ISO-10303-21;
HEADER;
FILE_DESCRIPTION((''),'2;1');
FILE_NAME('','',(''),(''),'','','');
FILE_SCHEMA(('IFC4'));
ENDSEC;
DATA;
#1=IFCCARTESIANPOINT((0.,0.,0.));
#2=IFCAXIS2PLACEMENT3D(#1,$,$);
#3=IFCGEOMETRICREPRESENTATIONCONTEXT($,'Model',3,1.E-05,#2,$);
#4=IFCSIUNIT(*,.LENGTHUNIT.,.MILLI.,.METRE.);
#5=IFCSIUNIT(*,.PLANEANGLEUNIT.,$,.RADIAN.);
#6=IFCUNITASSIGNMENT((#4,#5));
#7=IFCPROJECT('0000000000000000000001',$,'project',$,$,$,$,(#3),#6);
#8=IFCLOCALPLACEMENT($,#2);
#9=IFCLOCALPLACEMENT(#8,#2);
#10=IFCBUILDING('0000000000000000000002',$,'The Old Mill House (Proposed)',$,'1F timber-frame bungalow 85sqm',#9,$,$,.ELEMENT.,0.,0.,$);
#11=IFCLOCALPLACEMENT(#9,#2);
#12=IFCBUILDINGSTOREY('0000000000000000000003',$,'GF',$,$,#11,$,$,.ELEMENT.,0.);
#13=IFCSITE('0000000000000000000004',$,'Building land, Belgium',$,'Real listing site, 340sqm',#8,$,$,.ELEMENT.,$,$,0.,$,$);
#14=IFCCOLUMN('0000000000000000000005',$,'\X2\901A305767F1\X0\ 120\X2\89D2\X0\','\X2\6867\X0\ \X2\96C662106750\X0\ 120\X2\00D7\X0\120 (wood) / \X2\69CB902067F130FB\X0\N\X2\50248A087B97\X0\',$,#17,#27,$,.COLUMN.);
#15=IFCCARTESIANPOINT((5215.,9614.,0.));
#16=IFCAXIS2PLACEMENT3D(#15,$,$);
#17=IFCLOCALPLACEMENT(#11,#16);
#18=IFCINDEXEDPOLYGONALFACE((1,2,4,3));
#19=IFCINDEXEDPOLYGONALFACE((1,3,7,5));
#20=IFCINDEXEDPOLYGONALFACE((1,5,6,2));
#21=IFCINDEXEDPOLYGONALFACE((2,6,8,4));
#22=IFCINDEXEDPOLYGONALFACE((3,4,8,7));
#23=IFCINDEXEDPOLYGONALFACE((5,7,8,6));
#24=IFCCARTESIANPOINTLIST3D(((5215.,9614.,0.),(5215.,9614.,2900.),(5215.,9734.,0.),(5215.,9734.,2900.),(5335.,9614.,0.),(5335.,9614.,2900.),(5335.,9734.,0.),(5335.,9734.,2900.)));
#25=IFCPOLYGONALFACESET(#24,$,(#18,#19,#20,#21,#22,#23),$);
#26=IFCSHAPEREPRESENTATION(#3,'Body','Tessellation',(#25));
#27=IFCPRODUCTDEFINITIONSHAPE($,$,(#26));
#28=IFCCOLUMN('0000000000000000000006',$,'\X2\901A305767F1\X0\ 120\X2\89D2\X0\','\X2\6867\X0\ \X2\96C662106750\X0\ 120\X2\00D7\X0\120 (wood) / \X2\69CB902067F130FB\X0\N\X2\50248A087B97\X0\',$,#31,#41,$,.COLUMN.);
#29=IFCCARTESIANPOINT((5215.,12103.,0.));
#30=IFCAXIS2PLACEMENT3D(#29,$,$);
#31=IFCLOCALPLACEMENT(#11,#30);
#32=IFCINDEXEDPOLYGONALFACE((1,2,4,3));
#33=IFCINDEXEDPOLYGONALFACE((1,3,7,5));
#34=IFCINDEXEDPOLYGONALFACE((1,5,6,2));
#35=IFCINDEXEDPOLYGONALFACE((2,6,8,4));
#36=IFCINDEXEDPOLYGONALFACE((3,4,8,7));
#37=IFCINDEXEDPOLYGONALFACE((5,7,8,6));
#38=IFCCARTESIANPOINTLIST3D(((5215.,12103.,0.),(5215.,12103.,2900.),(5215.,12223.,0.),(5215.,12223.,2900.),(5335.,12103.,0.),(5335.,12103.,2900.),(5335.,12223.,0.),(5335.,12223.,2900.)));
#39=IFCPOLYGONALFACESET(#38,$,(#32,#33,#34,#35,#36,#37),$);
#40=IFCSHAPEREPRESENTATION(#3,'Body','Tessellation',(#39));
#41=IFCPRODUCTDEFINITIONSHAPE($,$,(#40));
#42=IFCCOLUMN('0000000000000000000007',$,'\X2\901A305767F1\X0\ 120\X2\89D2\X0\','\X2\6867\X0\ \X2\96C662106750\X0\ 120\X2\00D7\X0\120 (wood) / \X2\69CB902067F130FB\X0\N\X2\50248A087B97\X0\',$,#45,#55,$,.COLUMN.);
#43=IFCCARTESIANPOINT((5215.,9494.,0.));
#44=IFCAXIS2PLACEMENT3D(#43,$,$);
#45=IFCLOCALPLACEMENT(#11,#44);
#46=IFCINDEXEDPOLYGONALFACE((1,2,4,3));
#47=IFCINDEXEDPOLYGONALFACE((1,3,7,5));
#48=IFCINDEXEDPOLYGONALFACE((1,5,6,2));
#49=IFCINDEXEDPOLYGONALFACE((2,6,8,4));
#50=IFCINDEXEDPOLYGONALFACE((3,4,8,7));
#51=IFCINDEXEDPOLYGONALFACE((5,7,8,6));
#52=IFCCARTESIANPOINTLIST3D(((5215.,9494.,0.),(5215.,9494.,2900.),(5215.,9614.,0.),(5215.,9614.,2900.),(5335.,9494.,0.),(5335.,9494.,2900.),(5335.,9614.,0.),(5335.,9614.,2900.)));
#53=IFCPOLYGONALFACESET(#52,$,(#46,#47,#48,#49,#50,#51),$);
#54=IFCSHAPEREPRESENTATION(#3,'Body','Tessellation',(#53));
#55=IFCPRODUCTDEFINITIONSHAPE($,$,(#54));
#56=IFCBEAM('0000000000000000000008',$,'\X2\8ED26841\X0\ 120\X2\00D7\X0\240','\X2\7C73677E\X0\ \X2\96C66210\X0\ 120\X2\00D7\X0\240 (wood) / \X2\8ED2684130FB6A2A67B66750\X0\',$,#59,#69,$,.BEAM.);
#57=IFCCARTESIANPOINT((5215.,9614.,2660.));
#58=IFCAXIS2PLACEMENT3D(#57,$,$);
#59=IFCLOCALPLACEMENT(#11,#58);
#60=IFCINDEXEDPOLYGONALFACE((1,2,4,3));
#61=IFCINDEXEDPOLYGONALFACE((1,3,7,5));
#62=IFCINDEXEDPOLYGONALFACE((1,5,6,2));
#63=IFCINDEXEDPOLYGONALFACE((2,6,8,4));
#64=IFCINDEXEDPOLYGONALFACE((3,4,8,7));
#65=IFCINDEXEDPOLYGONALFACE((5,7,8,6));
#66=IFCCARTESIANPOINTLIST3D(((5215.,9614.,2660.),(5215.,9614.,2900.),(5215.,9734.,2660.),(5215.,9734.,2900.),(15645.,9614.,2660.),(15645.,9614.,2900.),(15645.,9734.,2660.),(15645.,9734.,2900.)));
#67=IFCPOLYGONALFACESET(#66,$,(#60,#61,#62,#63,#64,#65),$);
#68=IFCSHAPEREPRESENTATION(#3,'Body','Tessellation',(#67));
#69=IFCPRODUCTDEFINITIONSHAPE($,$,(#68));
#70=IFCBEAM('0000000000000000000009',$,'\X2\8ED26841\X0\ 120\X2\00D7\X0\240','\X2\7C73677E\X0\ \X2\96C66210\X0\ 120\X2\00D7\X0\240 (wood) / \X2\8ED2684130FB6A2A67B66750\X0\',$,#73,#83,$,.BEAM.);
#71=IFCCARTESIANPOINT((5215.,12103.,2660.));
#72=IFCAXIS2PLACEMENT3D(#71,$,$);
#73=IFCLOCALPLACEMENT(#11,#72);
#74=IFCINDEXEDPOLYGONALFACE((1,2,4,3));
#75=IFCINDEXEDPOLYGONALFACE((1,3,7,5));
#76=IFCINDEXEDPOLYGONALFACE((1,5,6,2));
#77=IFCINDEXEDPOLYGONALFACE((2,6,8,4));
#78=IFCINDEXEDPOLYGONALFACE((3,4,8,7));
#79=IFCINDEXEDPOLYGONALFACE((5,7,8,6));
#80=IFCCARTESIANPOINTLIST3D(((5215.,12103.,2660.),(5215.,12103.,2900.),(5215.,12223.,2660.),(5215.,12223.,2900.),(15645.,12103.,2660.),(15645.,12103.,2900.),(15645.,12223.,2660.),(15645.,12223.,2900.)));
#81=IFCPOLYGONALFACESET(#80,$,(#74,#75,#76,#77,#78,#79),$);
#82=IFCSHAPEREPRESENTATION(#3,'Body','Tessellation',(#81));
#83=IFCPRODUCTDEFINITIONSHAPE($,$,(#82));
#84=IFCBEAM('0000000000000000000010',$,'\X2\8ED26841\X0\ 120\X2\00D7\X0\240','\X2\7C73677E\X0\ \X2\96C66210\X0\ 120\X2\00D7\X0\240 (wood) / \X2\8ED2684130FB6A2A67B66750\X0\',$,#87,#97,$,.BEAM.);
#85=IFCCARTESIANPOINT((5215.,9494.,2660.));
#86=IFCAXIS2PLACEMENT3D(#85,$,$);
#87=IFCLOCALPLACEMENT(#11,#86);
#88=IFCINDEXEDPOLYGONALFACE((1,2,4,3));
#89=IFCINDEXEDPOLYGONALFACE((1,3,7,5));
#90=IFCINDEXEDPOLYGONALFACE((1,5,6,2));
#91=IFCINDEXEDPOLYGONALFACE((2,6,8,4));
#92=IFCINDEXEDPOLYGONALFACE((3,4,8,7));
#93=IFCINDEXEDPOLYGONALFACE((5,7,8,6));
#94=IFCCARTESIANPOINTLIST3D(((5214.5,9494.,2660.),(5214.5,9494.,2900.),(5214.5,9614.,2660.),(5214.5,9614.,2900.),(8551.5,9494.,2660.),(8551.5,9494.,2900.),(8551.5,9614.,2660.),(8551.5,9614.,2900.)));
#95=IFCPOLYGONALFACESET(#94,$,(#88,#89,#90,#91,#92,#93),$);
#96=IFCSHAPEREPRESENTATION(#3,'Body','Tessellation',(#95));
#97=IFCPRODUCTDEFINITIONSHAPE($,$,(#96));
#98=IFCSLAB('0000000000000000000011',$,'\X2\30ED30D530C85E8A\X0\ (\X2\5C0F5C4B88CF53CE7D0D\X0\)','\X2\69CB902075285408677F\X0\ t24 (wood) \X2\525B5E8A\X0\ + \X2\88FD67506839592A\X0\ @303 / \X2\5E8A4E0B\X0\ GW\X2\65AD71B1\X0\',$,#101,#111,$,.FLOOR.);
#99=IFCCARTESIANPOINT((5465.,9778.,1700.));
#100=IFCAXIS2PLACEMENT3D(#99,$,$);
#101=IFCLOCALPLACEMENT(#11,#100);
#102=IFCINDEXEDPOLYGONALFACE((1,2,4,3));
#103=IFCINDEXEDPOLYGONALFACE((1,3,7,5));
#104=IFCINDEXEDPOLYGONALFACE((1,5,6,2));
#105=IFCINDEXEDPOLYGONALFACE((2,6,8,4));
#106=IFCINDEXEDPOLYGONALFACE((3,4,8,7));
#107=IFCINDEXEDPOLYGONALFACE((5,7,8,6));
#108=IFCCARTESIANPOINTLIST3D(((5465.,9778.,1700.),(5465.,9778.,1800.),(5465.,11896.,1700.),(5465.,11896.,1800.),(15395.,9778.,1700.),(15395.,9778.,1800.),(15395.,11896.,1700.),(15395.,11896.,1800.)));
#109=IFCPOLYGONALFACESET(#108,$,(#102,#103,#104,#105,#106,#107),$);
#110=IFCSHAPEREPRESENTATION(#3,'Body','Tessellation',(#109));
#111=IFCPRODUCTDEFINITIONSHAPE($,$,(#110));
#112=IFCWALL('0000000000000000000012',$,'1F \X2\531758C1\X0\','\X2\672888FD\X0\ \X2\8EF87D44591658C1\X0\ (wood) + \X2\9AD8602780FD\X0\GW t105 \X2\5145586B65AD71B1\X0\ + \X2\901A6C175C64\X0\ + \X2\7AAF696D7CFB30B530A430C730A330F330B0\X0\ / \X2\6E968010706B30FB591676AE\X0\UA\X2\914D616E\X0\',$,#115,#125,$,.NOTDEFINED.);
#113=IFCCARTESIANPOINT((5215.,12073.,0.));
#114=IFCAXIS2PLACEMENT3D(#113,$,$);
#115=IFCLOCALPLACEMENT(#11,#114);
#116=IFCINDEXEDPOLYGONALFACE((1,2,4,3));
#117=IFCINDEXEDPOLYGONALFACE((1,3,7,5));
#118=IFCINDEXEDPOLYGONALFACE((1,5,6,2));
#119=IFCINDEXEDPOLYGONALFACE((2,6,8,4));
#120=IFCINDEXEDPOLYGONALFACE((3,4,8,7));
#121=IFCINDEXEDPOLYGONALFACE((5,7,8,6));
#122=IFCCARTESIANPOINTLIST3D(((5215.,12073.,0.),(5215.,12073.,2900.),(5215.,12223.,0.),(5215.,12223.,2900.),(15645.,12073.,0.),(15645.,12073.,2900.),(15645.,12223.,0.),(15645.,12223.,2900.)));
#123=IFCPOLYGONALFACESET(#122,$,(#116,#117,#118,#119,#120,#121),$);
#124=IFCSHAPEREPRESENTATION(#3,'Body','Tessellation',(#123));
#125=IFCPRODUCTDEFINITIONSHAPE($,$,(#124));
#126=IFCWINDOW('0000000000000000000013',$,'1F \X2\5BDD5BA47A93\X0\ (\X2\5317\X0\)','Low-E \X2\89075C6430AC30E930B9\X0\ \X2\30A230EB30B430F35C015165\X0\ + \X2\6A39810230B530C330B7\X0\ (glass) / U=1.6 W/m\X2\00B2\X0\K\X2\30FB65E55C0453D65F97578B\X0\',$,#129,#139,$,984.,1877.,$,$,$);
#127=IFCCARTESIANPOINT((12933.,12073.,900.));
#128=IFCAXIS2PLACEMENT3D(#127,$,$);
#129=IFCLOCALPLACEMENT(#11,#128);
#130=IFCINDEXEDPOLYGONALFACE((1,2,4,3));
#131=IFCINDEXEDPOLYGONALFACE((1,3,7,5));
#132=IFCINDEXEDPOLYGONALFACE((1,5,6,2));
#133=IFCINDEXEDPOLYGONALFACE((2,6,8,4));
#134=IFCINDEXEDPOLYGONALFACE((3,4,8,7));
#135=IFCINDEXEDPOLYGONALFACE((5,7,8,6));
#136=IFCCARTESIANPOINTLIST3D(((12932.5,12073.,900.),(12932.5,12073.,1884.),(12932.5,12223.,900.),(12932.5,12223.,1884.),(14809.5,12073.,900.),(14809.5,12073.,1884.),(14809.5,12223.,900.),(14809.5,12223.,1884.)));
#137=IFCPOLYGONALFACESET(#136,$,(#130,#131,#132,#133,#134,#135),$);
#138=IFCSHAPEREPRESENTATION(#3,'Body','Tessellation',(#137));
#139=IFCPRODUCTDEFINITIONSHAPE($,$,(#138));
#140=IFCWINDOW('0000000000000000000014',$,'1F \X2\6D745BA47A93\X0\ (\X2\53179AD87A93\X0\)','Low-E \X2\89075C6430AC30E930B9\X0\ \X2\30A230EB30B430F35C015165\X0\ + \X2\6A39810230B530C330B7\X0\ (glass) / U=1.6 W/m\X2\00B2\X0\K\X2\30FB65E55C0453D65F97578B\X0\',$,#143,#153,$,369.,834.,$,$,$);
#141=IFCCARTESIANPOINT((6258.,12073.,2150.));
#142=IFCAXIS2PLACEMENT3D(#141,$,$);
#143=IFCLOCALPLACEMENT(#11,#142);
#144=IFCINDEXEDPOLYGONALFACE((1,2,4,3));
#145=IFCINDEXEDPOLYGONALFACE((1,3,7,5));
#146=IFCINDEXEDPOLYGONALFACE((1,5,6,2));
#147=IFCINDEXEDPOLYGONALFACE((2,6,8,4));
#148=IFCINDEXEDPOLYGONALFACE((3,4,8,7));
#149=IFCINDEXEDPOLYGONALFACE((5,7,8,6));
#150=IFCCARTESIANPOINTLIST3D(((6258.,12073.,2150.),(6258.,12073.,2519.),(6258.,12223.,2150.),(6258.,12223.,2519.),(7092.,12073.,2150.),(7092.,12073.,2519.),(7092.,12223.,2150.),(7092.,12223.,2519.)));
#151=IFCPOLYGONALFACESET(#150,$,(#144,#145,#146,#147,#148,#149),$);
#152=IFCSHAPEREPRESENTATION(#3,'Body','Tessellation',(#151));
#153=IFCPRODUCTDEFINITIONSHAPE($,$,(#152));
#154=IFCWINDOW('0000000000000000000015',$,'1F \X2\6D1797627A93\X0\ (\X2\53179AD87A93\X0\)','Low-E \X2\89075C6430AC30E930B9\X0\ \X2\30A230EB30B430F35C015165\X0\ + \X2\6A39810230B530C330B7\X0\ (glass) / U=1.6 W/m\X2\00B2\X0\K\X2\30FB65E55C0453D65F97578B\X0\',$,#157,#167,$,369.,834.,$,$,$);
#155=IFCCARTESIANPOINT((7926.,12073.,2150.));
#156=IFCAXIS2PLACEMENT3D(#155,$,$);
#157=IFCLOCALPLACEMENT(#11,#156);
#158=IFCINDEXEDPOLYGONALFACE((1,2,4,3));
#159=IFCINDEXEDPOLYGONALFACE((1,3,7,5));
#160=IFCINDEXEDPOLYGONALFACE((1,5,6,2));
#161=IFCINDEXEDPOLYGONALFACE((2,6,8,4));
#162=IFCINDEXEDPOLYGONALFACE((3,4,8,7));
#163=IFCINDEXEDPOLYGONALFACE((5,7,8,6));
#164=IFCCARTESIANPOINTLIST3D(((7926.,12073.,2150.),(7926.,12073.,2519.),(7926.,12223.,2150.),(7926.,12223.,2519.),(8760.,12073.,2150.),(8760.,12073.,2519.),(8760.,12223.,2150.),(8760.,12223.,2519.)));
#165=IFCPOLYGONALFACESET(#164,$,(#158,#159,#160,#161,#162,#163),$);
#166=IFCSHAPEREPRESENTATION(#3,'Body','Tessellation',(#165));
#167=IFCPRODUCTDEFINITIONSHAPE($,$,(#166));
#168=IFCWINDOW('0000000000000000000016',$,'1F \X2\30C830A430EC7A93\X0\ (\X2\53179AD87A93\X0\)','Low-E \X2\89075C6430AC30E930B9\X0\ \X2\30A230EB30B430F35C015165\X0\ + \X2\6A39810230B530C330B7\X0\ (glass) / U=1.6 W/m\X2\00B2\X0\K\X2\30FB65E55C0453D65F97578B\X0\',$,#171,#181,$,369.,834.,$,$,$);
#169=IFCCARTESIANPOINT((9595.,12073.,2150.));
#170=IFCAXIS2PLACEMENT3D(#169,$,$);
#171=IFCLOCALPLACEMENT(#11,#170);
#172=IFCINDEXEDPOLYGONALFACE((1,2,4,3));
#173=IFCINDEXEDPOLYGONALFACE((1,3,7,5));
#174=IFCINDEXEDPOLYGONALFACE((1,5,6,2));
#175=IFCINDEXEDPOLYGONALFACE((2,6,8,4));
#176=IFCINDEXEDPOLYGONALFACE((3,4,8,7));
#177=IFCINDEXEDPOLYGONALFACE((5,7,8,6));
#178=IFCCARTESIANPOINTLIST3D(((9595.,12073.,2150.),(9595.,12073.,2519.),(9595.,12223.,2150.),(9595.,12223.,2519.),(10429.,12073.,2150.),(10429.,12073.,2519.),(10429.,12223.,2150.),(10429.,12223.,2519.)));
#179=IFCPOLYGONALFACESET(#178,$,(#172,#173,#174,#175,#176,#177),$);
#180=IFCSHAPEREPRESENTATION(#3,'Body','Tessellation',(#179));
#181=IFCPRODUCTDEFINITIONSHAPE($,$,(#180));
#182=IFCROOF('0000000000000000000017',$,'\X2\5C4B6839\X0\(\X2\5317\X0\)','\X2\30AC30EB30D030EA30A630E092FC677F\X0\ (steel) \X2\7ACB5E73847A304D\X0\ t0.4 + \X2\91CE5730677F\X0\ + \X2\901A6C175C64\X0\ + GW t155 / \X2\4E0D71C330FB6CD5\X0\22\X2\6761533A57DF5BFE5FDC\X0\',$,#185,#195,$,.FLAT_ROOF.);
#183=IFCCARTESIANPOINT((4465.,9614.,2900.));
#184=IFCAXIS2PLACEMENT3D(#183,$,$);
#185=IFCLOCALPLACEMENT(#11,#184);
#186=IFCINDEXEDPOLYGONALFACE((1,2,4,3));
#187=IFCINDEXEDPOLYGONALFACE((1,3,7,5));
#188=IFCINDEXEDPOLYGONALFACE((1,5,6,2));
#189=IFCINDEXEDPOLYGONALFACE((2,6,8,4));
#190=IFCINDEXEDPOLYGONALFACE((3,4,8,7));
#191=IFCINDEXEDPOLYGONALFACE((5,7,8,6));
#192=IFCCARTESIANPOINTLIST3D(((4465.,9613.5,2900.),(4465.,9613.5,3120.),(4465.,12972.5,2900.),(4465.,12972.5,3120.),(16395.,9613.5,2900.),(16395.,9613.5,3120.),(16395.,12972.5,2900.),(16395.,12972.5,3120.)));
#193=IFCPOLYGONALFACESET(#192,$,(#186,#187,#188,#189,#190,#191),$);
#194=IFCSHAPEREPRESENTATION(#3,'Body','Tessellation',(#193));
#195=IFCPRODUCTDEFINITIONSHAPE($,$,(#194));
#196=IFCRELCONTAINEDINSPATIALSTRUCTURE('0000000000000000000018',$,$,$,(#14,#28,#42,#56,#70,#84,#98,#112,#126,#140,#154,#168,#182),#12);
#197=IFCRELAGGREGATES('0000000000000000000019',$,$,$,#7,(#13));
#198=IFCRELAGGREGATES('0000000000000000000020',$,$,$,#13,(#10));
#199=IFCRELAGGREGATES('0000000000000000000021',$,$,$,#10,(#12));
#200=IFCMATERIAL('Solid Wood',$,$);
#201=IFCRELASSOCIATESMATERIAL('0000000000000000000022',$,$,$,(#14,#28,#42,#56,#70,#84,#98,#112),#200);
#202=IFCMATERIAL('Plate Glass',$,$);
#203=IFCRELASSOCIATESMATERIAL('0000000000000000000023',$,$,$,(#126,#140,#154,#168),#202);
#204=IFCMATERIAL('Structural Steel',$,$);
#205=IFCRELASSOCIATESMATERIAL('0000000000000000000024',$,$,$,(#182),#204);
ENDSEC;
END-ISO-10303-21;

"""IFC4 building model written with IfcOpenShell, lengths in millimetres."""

from ifc_helpers import new_model, si_unit, frame, frame_2d, origin, place, context, project, spatial, rectangle, extrude, material, element, fill, save


model = new_model("IFC4")

# Units and contexts
model_context = context("Model", 3, precision=1e-05, world=origin())
ifc_project = project(units=[si_unit("LENGTHUNIT", "METRE", prefix="MILLI"), si_unit("PLANEANGLEUNIT", "RADIAN")], contexts=[model_context])

# Site, building, storey
site_placement = place(None, origin())
site = spatial("IfcSite", under=ifc_project, at=site_placement, Name="Building land, Belgium", ObjectType="Real listing site, 340sqm", CompositionType="ELEMENT", RefElevation=0.0)
building_placement = place(site_placement, origin())
building = spatial("IfcBuilding", under=site, at=building_placement, Name="The Old Mill House (Proposed)", ObjectType="1F timber-frame bungalow 85sqm", CompositionType="ELEMENT", ElevationOfRefHeight=0.0, ElevationOfTerrain=0.0)
storey_placement = place(building_placement, origin())
storey = spatial("IfcBuildingStorey", under=building, at=storey_placement, Name="GF", CompositionType="ELEMENT", Elevation=0.0)

# Columns
ifc_material_1 = material(Name="Solid Wood")
column_1_placement = place(storey_placement, frame((5215.0, 9614.0, 0.0)))
element("IfcColumn", 1, at=column_1_placement, inside=storey, material=ifc_material_1, Name="通し柱 120角", Description="桧 集成材 120×120 (wood) / 構造柱・N値計算", PredefinedType="COLUMN", context=model_context, shape_type="SweptSolid", body=[
    extrude(rectangle(XDim=120.0, YDim=120.0, at=frame_2d((60.0, 60.0))), frame((5215.0, 9614.0, 0.0)), (0.0, 0.0, 1.0), 2900.0),
])
column_2_placement = place(storey_placement, frame((5215.0, 12103.0, 0.0)))
element("IfcColumn", 2, at=column_2_placement, inside=storey, material=ifc_material_1, Name="通し柱 120角", Description="桧 集成材 120×120 (wood) / 構造柱・N値計算", PredefinedType="COLUMN", context=model_context, shape_type="SweptSolid", body=[
    extrude(rectangle(XDim=120.0, YDim=120.0, at=frame_2d((60.0, 60.0))), frame((5215.0, 12103.0, 0.0)), (0.0, 0.0, 1.0), 2900.0),
])
column_3_placement = place(storey_placement, frame((5215.0, 9494.0, 0.0)))
element("IfcColumn", 3, at=column_3_placement, inside=storey, material=ifc_material_1, Name="通し柱 120角", Description="桧 集成材 120×120 (wood) / 構造柱・N値計算", PredefinedType="COLUMN", context=model_context, shape_type="SweptSolid", body=[
    extrude(rectangle(XDim=120.0, YDim=120.0, at=frame_2d((60.0, 60.0))), frame((5215.0, 9494.0, 0.0)), (0.0, 0.0, 1.0), 2900.0),
])

# Beams
beam_1_placement = place(storey_placement, frame((5215.0, 9614.0, 2660.0)))
element("IfcBeam", 4, at=beam_1_placement, inside=storey, material=ifc_material_1, Name="軒桁 120×240", Description="米松 集成 120×240 (wood) / 軒桁・横架材", PredefinedType="BEAM", context=model_context, shape_type="SweptSolid", body=[
    extrude(rectangle(XDim=10430.0, YDim=120.0, at=frame_2d((5215.0, 60.0))), frame((5215.0, 9614.0, 2660.0)), (0.0, 0.0, 1.0), 240.0),
])
beam_2_placement = place(storey_placement, frame((5215.0, 12103.0, 2660.0)))
element("IfcBeam", 5, at=beam_2_placement, inside=storey, material=ifc_material_1, Name="軒桁 120×240", Description="米松 集成 120×240 (wood) / 軒桁・横架材", PredefinedType="BEAM", context=model_context, shape_type="SweptSolid", body=[
    extrude(rectangle(XDim=10430.0, YDim=120.0, at=frame_2d((5215.0, 60.0))), frame((5215.0, 12103.0, 2660.0)), (0.0, 0.0, 1.0), 240.0),
])
beam_3_placement = place(storey_placement, frame((5215.0, 9494.0, 2660.0)))
element("IfcBeam", 6, at=beam_3_placement, inside=storey, material=ifc_material_1, Name="軒桁 120×240", Description="米松 集成 120×240 (wood) / 軒桁・横架材", PredefinedType="BEAM", context=model_context, shape_type="SweptSolid", body=[
    extrude(rectangle(XDim=3337.0, YDim=120.0, at=frame_2d((1668.0, 60.0))), frame((5215.0, 9494.0, 2660.0)), (0.0, 0.0, 1.0), 240.0),
])

# Slab
slab_1_placement = place(storey_placement, frame((5465.0, 9778.0, 1700.0)))
element("IfcSlab", 7, at=slab_1_placement, inside=storey, material=ifc_material_1, Name="ロフト床 (小屋裏収納)", Description="構造用合板 t24 (wood) 剛床 + 製材根太 @303 / 床下 GW断熱", PredefinedType="FLOOR", context=model_context, shape_type="SweptSolid", body=[
    extrude(rectangle(XDim=9930.0, YDim=2118.0, at=frame_2d((4965.0, 1059.0))), frame((5465.0, 9778.0, 1700.0)), (0.0, 0.0, 1.0), 100.0),
])

# Wall, openings, windows
wall_1_placement = place(storey_placement, frame((5215.0, 12073.0, 0.0)))
wall_1 = element("IfcWall", 8, at=wall_1_placement, inside=storey, material=ifc_material_1, Name="1F 北壁", Description="木製 軸組外壁 (wood) + 高性能GW t105 充填断熱 + 通気層 + 窯業系サイディング / 準耐火・外皮UA配慮", PredefinedType="NOTDEFINED", context=model_context, shape_type="SweptSolid", body=[
    extrude(rectangle(XDim=10430.0, YDim=150.0, at=frame_2d((5215.0, 75.0))), frame((5215.0, 12073.0, 0.0)), (0.0, 0.0, 1.0), 2900.0),
])
opening_1_placement = place(storey_placement, frame((12933.0, 12073.0, 900.0)))
opening_1 = element("IfcOpeningElement", 9, at=opening_1_placement, cuts=wall_1, PredefinedType="NOTDEFINED", context=model_context, shape_type="SweptSolid", body=[
    extrude(rectangle(XDim=1877.0, YDim=150.0, at=frame_2d((938.0, 75.0))), frame((12933.0, 12073.0, 900.0)), (0.0, 0.0, 1.0), 984.0),
])
opening_2_placement = place(storey_placement, frame((6258.0, 12073.0, 2150.0)))
opening_2 = element("IfcOpeningElement", 10, at=opening_2_placement, cuts=wall_1, PredefinedType="NOTDEFINED", context=model_context, shape_type="SweptSolid", body=[
    extrude(rectangle(XDim=834.0, YDim=150.0, at=frame_2d((417.0, 75.0))), frame((6258.0, 12073.0, 2150.0)), (0.0, 0.0, 1.0), 369.0),
])
opening_3_placement = place(storey_placement, frame((7926.0, 12073.0, 2150.0)))
opening_3 = element("IfcOpeningElement", 11, at=opening_3_placement, cuts=wall_1, PredefinedType="NOTDEFINED", context=model_context, shape_type="SweptSolid", body=[
    extrude(rectangle(XDim=834.0, YDim=150.0, at=frame_2d((417.0, 75.0))), frame((7926.0, 12073.0, 2150.0)), (0.0, 0.0, 1.0), 369.0),
])
opening_4_placement = place(storey_placement, frame((9595.0, 12073.0, 2150.0)))
opening_4 = element("IfcOpeningElement", 12, at=opening_4_placement, cuts=wall_1, PredefinedType="NOTDEFINED", context=model_context, shape_type="SweptSolid", body=[
    extrude(rectangle(XDim=834.0, YDim=150.0, at=frame_2d((417.0, 75.0))), frame((9595.0, 12073.0, 2150.0)), (0.0, 0.0, 1.0), 369.0),
])
ifc_material_2 = material(Name="Plate Glass")
window_1_placement = place(storey_placement, frame((12933.0, 12073.0, 900.0)))
window_1 = element("IfcWindow", 13, at=window_1_placement, inside=storey, material=ifc_material_2, Name="1F 寝室窓 (北)", Description="Low-E 複層ガラス アルゴン封入 + 樹脂サッシ (glass) / U=1.6 W/m²K・日射取得型", OverallHeight=984.0, OverallWidth=1877.0, context=model_context, shape_type="SweptSolid", body=[
    extrude(rectangle(XDim=1877.0, YDim=150.0, at=frame_2d((938.0, 75.0))), frame((12933.0, 12073.0, 900.0)), (0.0, 0.0, 1.0), 984.0),
])
fill(opening_1, window_1)
window_2_placement = place(storey_placement, frame((6258.0, 12073.0, 2150.0)))
window_2 = element("IfcWindow", 14, at=window_2_placement, inside=storey, material=ifc_material_2, Name="1F 浴室窓 (北高窓)", Description="Low-E 複層ガラス アルゴン封入 + 樹脂サッシ (glass) / U=1.6 W/m²K・日射取得型", OverallHeight=369.0, OverallWidth=834.0, context=model_context, shape_type="SweptSolid", body=[
    extrude(rectangle(XDim=834.0, YDim=150.0, at=frame_2d((417.0, 75.0))), frame((6258.0, 12073.0, 2150.0)), (0.0, 0.0, 1.0), 369.0),
])
fill(opening_2, window_2)
window_3_placement = place(storey_placement, frame((7926.0, 12073.0, 2150.0)))
window_3 = element("IfcWindow", 15, at=window_3_placement, inside=storey, material=ifc_material_2, Name="1F 洗面窓 (北高窓)", Description="Low-E 複層ガラス アルゴン封入 + 樹脂サッシ (glass) / U=1.6 W/m²K・日射取得型", OverallHeight=369.0, OverallWidth=834.0, context=model_context, shape_type="SweptSolid", body=[
    extrude(rectangle(XDim=834.0, YDim=150.0, at=frame_2d((417.0, 75.0))), frame((7926.0, 12073.0, 2150.0)), (0.0, 0.0, 1.0), 369.0),
])
fill(opening_3, window_3)
window_4_placement = place(storey_placement, frame((9595.0, 12073.0, 2150.0)))
window_4 = element("IfcWindow", 16, at=window_4_placement, inside=storey, material=ifc_material_2, Name="1F トイレ窓 (北高窓)", Description="Low-E 複層ガラス アルゴン封入 + 樹脂サッシ (glass) / U=1.6 W/m²K・日射取得型", OverallHeight=369.0, OverallWidth=834.0, context=model_context, shape_type="SweptSolid", body=[
    extrude(rectangle(XDim=834.0, YDim=150.0, at=frame_2d((417.0, 75.0))), frame((9595.0, 12073.0, 2150.0)), (0.0, 0.0, 1.0), 369.0),
])
fill(opening_4, window_4)

# Roof
ifc_material_3 = material(Name="Structural Steel")
roof_placement = place(storey_placement, frame((4465.0, 9614.0, 2900.0)))
element("IfcRoof", 17, at=roof_placement, inside=storey, material=ifc_material_3, Name="屋根(北)", Description="ガルバリウム鋼板 (steel) 立平葺き t0.4 + 野地板 + 通気層 + GW t155 / 不燃・法22条区域対応", PredefinedType="FLAT_ROOF", context=model_context, shape_type="SweptSolid", body=[
    extrude(rectangle(XDim=11930.0, YDim=3359.0, at=frame_2d((5965.0, 1679.0))), frame((4465.0, 9614.0, 2900.0)), (0.0, 0.0, 1.0), 220.0),
])

save(model, "model.ifc")
